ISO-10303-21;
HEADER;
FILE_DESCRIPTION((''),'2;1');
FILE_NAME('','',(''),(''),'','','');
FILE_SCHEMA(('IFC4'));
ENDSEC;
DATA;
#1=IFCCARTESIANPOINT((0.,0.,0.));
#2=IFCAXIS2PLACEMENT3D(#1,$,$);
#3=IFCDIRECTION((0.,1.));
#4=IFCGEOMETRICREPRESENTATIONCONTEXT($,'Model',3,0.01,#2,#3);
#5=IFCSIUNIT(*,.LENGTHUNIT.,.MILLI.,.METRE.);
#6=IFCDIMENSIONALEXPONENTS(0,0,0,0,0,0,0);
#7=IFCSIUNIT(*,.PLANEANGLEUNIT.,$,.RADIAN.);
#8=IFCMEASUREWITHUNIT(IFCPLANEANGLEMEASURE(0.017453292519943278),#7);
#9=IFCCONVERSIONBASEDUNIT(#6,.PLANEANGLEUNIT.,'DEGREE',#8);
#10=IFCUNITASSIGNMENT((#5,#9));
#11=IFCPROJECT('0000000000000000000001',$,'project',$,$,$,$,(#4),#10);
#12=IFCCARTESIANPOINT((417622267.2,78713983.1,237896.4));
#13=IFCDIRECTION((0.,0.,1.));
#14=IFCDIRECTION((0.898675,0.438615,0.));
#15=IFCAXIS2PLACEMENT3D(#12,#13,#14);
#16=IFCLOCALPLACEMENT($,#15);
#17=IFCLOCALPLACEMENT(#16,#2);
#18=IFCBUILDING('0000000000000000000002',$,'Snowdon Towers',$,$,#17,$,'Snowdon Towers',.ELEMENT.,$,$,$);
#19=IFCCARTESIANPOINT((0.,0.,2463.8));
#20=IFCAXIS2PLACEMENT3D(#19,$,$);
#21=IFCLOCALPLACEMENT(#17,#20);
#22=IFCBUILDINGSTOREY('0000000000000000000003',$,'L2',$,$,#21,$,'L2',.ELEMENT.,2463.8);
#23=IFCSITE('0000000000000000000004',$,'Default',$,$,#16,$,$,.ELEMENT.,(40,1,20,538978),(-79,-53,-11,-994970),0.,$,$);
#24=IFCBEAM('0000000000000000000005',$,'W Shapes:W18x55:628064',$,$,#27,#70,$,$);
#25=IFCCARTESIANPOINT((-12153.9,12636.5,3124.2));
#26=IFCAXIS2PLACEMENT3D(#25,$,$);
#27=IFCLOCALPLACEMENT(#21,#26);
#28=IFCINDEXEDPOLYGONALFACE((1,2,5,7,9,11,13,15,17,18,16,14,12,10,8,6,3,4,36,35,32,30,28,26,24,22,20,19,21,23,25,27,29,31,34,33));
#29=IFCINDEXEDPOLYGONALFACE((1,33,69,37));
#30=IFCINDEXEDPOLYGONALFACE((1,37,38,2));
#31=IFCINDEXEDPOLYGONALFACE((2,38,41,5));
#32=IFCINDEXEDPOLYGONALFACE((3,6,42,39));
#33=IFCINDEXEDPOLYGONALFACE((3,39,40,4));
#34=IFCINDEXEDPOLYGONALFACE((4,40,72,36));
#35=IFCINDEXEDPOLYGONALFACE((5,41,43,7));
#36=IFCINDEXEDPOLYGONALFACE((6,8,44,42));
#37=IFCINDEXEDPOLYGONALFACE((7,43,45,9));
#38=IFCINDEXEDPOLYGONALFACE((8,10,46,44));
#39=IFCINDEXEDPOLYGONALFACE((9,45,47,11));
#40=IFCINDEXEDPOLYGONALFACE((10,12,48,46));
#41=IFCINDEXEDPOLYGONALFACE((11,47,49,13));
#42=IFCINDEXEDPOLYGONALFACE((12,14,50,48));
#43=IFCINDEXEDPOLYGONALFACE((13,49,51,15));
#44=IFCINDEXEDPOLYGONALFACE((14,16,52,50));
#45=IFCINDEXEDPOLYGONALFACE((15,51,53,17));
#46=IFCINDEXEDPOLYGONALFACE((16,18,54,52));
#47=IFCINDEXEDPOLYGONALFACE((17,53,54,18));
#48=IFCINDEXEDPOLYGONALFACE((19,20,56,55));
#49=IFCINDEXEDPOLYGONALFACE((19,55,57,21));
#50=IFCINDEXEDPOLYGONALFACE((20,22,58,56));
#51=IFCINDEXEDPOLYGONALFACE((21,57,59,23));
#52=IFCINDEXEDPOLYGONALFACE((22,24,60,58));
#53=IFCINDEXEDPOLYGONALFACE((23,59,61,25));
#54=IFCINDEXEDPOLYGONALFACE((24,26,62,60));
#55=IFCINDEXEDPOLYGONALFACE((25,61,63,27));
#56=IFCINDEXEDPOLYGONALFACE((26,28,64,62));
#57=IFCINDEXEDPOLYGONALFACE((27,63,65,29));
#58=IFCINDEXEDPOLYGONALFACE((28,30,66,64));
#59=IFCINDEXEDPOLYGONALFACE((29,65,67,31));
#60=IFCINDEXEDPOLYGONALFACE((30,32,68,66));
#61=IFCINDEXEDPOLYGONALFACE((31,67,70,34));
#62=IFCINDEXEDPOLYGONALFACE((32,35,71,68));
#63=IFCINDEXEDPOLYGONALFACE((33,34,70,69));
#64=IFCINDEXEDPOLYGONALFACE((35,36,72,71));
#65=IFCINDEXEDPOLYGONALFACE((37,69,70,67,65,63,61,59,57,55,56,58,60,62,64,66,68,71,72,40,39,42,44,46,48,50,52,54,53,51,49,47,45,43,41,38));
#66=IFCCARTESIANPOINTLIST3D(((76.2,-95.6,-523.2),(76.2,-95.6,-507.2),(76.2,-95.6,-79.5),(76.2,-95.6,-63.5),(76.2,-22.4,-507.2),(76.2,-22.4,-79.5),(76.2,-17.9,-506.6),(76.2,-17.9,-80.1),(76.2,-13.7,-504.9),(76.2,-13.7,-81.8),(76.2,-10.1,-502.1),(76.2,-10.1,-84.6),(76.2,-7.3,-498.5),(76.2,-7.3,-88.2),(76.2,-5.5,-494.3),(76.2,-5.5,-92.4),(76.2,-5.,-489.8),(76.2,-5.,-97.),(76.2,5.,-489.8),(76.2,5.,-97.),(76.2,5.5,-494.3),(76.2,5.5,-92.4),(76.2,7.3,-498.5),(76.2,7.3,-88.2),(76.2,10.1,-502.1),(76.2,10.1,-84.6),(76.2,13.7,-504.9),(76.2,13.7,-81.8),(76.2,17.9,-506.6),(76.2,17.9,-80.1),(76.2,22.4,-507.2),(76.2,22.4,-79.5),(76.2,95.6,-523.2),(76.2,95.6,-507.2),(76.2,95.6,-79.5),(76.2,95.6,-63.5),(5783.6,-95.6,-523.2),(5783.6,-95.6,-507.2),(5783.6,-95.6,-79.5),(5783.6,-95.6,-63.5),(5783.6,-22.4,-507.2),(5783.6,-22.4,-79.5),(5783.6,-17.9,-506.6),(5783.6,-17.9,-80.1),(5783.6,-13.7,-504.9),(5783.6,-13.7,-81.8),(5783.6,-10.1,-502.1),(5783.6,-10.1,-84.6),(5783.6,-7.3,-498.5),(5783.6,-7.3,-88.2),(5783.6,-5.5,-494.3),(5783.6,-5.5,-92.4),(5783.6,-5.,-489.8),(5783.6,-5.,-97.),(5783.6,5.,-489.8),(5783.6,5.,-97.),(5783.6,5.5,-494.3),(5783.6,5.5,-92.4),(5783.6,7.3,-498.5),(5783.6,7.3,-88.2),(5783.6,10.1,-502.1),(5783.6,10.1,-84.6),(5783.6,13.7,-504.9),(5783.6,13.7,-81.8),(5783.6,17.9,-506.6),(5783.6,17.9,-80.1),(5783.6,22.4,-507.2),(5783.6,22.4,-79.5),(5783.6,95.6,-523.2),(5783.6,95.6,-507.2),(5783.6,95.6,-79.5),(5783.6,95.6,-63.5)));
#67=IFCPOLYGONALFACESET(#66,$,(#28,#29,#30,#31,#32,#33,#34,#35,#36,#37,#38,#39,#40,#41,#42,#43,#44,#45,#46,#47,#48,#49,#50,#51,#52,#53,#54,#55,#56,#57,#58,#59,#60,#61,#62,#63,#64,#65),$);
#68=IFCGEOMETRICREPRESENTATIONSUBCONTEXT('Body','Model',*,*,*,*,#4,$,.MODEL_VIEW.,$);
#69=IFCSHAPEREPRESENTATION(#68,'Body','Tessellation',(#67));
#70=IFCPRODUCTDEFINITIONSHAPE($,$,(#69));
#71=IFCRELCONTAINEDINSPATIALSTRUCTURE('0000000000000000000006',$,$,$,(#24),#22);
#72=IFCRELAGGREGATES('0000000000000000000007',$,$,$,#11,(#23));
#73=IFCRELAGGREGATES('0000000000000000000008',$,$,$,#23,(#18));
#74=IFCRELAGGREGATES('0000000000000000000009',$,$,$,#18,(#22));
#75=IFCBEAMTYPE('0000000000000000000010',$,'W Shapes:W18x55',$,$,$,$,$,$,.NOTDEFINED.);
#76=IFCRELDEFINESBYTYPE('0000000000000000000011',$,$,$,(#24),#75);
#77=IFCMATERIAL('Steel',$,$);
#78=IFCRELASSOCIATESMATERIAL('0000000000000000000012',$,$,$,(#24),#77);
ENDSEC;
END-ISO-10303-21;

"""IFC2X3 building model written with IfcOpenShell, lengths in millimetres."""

from ifc_helpers import new_model, entity, si_unit, converted_unit, direction, frame, frame_2d, origin, place, context, subcontext, project, spatial, i_section, extrude, material, type_object, element, save


model = new_model("IFC2X3")

# Units and contexts
model_context = context("Model", 3, precision=0.01, world=origin(), true_north=direction((0.0, 1.0)))
body_context = subcontext(model_context, "Body", "Model", "MODEL_VIEW")
ifc_project = project(units=[si_unit("LENGTHUNIT", "METRE", prefix="MILLI"), converted_unit("PLANEANGLEUNIT", "DEGREE", entity("IfcPlaneAngleMeasure", 0.017453292519943278), si_unit("PLANEANGLEUNIT", "RADIAN"), dimensions=[0, 0, 0, 0, 0, 0, 0])], contexts=[model_context])

# Site, building, storey
site_placement = place(None, frame((417622267.2, 78713983.1, 237896.4), z_axis=(0.0, 0.0, 1.0), x_axis=(0.898675, 0.438615, 0.0)))
site = spatial("IfcSite", under=ifc_project, at=site_placement, Name="Default", CompositionType="ELEMENT", RefLatitude=(40, 1, 20, 538978), RefLongitude=(-79, -53, -11, -994970), RefElevation=0.0)
building_placement = place(site_placement, origin())
building = spatial("IfcBuilding", under=site, at=building_placement, Name="Snowdon Towers", LongName="Snowdon Towers", CompositionType="ELEMENT")
storey_placement = place(building_placement, frame((0.0, 0.0, 2463.8)))
storey = spatial("IfcBuildingStorey", under=building, at=storey_placement, Name="L2", LongName="L2", CompositionType="ELEMENT", Elevation=2463.8)

# Beam
ifc_material_1 = material(Name="Steel")
beam_type_1 = type_object("IfcBeamType", Name="W Shapes:W18x55", PredefinedType="NOTDEFINED")
beam_1_placement = place(storey_placement, frame((-12153.9, 12636.5, 3124.2)))
element("IfcBeam", 1, at=beam_1_placement, inside=storey, type_object=beam_type_1, material=ifc_material_1, Name="W Shapes:W18x55:628064", context=body_context, shape_type="SweptSolid", body=[
    extrude(i_section(OverallWidth=191.3, OverallDepth=459.7, WebThickness=9.9, FlangeThickness=16.0, FilletRadius=17.5, at=frame_2d((0.0, 0.0), x_axis=(0.0, 1.0))), frame((76.2, 0.0, -293.4), z_axis=(1.0, 0.0, 0.0), x_axis=(0.0, 0.0, -1.0)), (0.0, 0.0, 1.0), 5707.4),
])

save(model, "model.ifc")
